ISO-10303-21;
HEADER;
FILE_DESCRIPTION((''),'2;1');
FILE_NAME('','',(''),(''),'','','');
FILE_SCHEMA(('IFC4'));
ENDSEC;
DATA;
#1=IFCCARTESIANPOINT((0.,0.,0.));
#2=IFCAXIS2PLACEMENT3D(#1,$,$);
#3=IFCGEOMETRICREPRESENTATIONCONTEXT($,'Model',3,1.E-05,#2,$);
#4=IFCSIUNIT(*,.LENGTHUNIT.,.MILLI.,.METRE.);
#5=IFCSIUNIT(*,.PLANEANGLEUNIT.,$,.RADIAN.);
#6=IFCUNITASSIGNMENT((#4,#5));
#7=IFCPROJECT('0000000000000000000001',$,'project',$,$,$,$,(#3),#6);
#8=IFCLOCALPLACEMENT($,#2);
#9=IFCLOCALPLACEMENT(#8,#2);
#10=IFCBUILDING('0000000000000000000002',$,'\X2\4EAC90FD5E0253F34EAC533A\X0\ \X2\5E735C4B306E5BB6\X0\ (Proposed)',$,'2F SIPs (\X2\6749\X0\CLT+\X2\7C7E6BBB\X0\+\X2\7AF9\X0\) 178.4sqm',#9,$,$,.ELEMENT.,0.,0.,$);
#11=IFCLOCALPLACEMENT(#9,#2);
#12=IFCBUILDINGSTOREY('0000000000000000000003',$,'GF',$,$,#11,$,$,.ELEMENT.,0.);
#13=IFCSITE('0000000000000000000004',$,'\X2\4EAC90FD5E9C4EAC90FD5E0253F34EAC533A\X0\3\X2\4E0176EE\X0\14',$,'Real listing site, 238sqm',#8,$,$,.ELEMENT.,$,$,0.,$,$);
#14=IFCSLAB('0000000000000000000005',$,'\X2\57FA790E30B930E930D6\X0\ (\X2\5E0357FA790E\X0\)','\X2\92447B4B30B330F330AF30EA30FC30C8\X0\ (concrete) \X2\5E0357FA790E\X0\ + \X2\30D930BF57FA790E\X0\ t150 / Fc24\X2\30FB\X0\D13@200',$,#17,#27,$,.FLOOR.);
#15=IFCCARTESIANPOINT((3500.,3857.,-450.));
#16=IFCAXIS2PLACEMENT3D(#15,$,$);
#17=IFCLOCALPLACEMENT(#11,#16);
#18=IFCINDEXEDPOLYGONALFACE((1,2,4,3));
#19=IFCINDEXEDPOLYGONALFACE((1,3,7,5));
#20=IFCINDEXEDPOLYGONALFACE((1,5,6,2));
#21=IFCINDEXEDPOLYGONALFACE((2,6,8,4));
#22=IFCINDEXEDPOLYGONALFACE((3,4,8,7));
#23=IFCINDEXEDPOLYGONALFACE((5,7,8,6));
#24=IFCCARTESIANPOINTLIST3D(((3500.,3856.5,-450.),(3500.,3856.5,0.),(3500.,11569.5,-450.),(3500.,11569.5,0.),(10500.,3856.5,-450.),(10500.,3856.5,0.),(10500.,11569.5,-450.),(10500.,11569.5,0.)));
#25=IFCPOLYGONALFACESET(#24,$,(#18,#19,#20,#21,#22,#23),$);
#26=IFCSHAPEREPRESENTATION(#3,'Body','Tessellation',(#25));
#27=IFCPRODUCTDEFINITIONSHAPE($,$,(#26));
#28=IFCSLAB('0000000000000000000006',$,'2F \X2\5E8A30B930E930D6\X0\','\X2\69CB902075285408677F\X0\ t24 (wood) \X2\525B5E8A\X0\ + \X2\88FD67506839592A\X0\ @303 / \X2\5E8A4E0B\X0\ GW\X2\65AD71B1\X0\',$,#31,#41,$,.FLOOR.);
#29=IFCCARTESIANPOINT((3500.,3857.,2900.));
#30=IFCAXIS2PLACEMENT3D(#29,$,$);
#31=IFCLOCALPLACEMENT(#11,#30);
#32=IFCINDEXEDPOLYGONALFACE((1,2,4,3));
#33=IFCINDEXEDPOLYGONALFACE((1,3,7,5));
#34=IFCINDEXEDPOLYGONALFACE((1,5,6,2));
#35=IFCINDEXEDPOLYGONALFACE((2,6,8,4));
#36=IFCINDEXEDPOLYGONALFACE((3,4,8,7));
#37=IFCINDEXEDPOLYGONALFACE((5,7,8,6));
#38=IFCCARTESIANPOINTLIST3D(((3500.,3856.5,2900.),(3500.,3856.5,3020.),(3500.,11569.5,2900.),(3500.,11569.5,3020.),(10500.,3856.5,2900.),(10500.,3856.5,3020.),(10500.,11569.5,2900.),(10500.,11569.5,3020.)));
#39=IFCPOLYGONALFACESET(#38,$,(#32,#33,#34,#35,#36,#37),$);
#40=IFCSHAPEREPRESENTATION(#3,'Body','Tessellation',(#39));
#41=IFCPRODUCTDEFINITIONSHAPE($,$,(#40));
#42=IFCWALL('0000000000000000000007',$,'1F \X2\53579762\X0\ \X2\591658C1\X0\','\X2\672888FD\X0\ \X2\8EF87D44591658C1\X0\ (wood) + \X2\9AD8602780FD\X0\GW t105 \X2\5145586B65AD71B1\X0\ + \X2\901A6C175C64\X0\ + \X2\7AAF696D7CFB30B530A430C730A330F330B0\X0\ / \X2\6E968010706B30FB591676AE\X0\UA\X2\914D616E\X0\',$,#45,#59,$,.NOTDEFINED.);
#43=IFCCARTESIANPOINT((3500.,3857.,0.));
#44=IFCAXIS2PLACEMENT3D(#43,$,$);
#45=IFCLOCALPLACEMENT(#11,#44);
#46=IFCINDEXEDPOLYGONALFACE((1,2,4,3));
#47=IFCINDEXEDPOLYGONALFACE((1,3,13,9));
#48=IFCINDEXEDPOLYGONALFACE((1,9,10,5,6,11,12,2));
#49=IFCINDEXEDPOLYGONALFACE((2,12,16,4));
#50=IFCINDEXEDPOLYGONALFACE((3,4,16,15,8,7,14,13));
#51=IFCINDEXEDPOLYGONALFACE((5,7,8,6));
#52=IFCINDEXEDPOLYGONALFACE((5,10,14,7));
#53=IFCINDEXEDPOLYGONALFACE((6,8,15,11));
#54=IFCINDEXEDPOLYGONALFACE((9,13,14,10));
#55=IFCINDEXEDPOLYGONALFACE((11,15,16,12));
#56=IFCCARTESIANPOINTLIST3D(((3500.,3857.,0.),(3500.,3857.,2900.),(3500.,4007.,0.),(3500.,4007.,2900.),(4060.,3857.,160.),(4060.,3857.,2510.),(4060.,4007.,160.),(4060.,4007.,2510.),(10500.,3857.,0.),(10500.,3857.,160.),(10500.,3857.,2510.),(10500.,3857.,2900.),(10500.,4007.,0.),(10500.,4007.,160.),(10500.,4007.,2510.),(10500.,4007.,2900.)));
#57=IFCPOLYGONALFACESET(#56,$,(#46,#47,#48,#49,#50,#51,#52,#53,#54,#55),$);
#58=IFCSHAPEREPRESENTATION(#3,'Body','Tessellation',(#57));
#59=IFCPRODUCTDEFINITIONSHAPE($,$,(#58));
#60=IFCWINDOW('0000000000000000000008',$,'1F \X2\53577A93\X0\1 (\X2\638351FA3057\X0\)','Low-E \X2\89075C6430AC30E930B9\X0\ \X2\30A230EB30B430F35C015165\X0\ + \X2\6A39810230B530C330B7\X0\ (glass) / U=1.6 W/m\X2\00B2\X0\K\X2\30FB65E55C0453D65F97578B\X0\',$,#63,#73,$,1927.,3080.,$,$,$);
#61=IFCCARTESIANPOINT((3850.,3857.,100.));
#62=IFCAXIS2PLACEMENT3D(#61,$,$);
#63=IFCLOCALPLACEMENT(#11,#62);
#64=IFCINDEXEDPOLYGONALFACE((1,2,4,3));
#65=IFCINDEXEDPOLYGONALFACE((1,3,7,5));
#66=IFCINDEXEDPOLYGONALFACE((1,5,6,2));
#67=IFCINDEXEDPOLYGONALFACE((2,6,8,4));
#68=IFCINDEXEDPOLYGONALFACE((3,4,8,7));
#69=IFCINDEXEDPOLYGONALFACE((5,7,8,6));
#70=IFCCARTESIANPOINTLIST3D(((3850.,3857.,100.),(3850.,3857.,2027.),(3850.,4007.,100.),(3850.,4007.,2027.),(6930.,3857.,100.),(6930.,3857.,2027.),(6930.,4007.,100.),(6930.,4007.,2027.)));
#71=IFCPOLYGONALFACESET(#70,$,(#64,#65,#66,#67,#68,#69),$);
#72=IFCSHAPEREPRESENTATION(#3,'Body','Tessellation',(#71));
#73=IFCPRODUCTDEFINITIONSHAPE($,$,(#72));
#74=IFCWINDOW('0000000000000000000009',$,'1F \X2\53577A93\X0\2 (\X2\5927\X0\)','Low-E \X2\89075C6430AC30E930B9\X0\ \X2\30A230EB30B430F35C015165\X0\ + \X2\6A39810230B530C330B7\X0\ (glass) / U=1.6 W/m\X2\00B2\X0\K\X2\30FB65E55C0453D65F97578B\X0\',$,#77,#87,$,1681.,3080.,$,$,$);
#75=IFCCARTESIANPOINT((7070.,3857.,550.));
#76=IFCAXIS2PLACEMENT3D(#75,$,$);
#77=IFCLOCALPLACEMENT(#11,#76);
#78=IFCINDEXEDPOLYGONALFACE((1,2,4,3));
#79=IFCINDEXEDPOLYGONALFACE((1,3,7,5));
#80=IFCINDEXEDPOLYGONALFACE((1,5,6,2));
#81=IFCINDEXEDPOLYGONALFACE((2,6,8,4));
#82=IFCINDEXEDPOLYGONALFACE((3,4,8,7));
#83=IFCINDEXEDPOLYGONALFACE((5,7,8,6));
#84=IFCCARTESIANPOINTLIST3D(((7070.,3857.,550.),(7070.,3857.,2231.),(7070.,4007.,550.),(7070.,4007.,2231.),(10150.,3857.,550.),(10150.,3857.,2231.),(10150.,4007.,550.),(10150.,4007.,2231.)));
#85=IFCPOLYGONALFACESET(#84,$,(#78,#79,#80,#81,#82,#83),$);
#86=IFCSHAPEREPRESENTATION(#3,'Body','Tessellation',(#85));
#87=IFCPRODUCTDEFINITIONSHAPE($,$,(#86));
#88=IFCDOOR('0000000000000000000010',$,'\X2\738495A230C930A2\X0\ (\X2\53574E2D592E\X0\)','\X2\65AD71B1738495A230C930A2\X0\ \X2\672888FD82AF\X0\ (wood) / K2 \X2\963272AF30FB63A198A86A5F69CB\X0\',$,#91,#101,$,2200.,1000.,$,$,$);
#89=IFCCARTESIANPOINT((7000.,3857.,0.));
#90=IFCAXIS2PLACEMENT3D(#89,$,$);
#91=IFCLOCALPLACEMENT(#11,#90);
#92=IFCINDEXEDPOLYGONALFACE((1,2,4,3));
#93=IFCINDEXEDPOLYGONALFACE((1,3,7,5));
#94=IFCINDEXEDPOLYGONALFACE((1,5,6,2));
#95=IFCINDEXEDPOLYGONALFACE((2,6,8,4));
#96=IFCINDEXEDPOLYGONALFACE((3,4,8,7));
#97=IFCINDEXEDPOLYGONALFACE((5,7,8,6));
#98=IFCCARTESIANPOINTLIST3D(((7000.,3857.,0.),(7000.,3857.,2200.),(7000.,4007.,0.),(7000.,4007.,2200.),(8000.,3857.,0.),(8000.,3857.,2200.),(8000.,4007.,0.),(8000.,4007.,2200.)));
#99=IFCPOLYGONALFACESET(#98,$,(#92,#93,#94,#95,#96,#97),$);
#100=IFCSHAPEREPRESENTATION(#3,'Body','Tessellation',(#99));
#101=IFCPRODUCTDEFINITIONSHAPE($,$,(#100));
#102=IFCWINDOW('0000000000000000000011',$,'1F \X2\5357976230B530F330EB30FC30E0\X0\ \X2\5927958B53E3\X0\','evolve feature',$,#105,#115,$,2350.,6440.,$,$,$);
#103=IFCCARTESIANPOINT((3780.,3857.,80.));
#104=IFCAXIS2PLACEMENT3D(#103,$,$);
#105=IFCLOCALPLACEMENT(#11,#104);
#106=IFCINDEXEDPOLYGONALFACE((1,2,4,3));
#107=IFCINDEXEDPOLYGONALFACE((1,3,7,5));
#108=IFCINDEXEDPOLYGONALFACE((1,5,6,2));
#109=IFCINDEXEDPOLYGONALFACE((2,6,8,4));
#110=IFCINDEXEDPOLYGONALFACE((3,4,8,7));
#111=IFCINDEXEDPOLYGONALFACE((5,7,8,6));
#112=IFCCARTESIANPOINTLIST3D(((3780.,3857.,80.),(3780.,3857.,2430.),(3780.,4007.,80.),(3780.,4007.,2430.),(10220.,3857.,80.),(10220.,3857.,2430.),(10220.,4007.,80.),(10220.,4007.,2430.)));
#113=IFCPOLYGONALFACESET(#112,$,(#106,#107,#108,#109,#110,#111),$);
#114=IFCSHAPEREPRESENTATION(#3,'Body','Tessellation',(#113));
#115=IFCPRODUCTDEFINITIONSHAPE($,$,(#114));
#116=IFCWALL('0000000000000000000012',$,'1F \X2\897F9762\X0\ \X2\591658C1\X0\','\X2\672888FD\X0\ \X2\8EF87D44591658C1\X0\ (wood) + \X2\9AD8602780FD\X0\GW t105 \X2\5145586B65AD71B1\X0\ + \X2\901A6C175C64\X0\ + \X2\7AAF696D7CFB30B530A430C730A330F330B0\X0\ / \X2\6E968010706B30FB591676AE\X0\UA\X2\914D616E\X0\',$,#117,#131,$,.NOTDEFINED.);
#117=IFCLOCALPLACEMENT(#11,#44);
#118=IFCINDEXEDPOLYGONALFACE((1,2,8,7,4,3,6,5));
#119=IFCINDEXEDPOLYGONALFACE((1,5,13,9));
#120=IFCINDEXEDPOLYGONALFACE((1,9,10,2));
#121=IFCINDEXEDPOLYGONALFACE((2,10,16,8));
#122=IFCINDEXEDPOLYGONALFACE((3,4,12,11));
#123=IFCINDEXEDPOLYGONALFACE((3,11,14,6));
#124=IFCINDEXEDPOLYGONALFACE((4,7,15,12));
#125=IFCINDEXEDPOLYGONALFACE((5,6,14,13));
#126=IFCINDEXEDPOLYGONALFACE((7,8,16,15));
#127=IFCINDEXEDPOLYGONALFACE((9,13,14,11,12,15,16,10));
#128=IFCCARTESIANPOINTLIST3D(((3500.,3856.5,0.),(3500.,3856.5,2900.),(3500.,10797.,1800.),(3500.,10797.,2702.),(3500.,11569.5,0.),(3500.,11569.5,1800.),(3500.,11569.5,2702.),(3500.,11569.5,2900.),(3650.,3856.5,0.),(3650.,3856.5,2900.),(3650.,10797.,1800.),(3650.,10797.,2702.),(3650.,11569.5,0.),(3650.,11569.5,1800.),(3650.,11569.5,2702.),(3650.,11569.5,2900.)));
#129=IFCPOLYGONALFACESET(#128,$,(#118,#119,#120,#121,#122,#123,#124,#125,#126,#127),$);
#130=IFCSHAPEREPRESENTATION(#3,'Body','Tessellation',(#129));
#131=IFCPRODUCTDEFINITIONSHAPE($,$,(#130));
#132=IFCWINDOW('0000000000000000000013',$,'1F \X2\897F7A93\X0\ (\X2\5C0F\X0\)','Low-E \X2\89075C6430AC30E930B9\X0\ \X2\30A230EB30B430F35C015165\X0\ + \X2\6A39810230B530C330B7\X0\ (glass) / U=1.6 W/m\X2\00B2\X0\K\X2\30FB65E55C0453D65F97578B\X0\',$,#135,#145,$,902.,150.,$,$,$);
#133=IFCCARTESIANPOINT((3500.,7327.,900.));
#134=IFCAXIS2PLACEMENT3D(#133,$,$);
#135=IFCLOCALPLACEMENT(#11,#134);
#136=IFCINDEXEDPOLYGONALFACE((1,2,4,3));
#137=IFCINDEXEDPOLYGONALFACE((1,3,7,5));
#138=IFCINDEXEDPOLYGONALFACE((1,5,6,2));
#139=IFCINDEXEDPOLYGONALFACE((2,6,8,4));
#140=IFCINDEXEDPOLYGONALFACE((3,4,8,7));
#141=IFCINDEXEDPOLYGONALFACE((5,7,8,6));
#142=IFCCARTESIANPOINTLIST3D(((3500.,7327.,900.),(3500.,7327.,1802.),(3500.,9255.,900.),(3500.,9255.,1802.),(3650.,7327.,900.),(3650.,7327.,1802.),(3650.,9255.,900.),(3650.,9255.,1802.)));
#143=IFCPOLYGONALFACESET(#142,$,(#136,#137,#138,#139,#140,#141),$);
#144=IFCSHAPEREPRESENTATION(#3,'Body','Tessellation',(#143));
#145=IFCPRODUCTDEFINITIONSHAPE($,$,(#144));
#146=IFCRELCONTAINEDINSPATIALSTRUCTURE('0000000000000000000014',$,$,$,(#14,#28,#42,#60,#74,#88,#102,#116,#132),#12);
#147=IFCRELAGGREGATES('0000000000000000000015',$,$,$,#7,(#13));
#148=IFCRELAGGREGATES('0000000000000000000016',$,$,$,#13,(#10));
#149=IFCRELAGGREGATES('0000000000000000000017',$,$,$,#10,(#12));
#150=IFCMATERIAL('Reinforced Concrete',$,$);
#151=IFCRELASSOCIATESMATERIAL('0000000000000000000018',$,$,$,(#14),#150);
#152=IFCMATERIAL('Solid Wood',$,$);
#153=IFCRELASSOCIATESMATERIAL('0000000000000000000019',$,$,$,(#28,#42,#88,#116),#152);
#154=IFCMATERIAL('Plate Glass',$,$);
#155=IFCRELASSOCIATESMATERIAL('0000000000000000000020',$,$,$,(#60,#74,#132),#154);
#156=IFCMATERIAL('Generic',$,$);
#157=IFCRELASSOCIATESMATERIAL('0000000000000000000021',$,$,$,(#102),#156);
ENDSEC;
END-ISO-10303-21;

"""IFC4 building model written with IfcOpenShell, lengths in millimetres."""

from ifc_helpers import new_model, si_unit, frame, frame_2d, origin, place, context, project, spatial, rectangle, extrude, material, element, fill, save


model = new_model("IFC4")

# Units and contexts
model_context = context("Model", 3, precision=1e-05, world=origin())
ifc_project = project(units=[si_unit("LENGTHUNIT", "METRE", prefix="MILLI"), si_unit("PLANEANGLEUNIT", "RADIAN")], contexts=[model_context])

# Site, building, storey
site_placement = place(None, origin())
site = spatial("IfcSite", under=ifc_project, at=site_placement, Name="京都府京都市右京区3丁目14", ObjectType="Real listing site, 238sqm", CompositionType="ELEMENT", RefElevation=0.0)
building_placement = place(site_placement, origin())
building = spatial("IfcBuilding", under=site, at=building_placement, Name="京都市右京区 平屋の家 (Proposed)", ObjectType="2F SIPs (杉CLT+籾殻+竹) 178.4sqm", CompositionType="ELEMENT", ElevationOfRefHeight=0.0, ElevationOfTerrain=0.0)
storey_placement = place(building_placement, origin())
storey = spatial("IfcBuildingStorey", under=building, at=storey_placement, Name="GF", CompositionType="ELEMENT", Elevation=0.0)

# Slabs
ifc_material_1 = material(Name="Reinforced Concrete")
slab_1_placement = place(storey_placement, frame((3500.0, 3857.0, -450.0)))
element("IfcSlab", 1, at=slab_1_placement, inside=storey, material=ifc_material_1, Name="基礎スラブ (布基礎)", Description="鉄筋コンクリート (concrete) 布基礎 + ベタ基礎 t150 / Fc24・D13@200", PredefinedType="FLOOR", context=model_context, shape_type="SweptSolid", body=[
    extrude(rectangle(XDim=7000.0, YDim=7713.0, at=frame_2d((3500.0, 3856.0))), frame((3500.0, 3857.0, -450.0)), (0.0, 0.0, 1.0), 450.0),
])
ifc_material_2 = material(Name="Solid Wood")
slab_2_placement = place(storey_placement, frame((3500.0, 3857.0, 2900.0)))
element("IfcSlab", 2, at=slab_2_placement, inside=storey, material=ifc_material_2, Name="2F 床スラブ", Description="構造用合板 t24 (wood) 剛床 + 製材根太 @303 / 床下 GW断熱", PredefinedType="FLOOR", context=model_context, shape_type="SweptSolid", body=[
    extrude(rectangle(XDim=7000.0, YDim=7713.0, at=frame_2d((3500.0, 3856.0))), frame((3500.0, 3857.0, 2900.0)), (0.0, 0.0, 1.0), 120.0),
])
ifc_material_3 = material(Name="Generic")

# Wall, openings, windows, door
wall_1_placement = place(storey_placement, frame((3500.0, 3857.0, 0.0)))
wall_1 = element("IfcWall", 3, at=wall_1_placement, inside=storey, material=ifc_material_2, Name="1F 南面 外壁", Description="木製 軸組外壁 (wood) + 高性能GW t105 充填断熱 + 通気層 + 窯業系サイディング / 準耐火・外皮UA配慮", PredefinedType="NOTDEFINED", context=model_context, shape_type="SweptSolid", body=[
    extrude(rectangle(XDim=7000.0, YDim=150.0, at=frame_2d((3500.0, 75.0))), frame((3500.0, 3857.0, 0.0)), (0.0, 0.0, 1.0), 2900.0),
])
opening_1_placement = place(storey_placement, frame((3850.0, 3857.0, 100.0)))
opening_1 = element("IfcOpeningElement", 4, at=opening_1_placement, cuts=wall_1, PredefinedType="NOTDEFINED", context=model_context, shape_type="SweptSolid", body=[
    extrude(rectangle(XDim=3080.0, YDim=150.0, at=frame_2d((1540.0, 75.0))), frame((3850.0, 3857.0, 100.0)), (0.0, 0.0, 1.0), 1927.0),
])
opening_2_placement = place(storey_placement, frame((7070.0, 3857.0, 550.0)))
opening_2 = element("IfcOpeningElement", 5, at=opening_2_placement, cuts=wall_1, PredefinedType="NOTDEFINED", context=model_context, shape_type="SweptSolid", body=[
    extrude(rectangle(XDim=3080.0, YDim=150.0, at=frame_2d((1540.0, 75.0))), frame((7070.0, 3857.0, 550.0)), (0.0, 0.0, 1.0), 1681.0),
])
opening_3_placement = place(storey_placement, frame((7000.0, 3857.0, 0.0)))
opening_3 = element("IfcOpeningElement", 6, at=opening_3_placement, cuts=wall_1, PredefinedType="NOTDEFINED", context=model_context, shape_type="SweptSolid", body=[
    extrude(rectangle(XDim=1000.0, YDim=150.0, at=frame_2d((500.0, 75.0))), frame((7000.0, 3857.0, 0.0)), (0.0, 0.0, 1.0), 2200.0),
])
opening_4_placement = place(storey_placement, frame((3780.0, 3857.0, 80.0)))
opening_4 = element("IfcOpeningElement", 7, at=opening_4_placement, cuts=wall_1, PredefinedType="NOTDEFINED", context=model_context, shape_type="SweptSolid", body=[
    extrude(rectangle(XDim=6440.0, YDim=150.0, at=frame_2d((3220.0, 75.0))), frame((3780.0, 3857.0, 80.0)), (0.0, 0.0, 1.0), 2350.0),
])
ifc_material_4 = material(Name="Plate Glass")
window_1_placement = place(storey_placement, frame((3850.0, 3857.0, 100.0)))
window_1 = element("IfcWindow", 8, at=window_1_placement, inside=storey, material=ifc_material_4, Name="1F 南窓1 (掃出し)", Description="Low-E 複層ガラス アルゴン封入 + 樹脂サッシ (glass) / U=1.6 W/m²K・日射取得型", OverallHeight=1927.0, OverallWidth=3080.0, context=model_context, shape_type="SweptSolid", body=[
    extrude(rectangle(XDim=3080.0, YDim=150.0, at=frame_2d((1540.0, 75.0))), frame((3850.0, 3857.0, 100.0)), (0.0, 0.0, 1.0), 1927.0),
])
fill(opening_1, window_1)
window_2_placement = place(storey_placement, frame((7070.0, 3857.0, 550.0)))
window_2 = element("IfcWindow", 9, at=window_2_placement, inside=storey, material=ifc_material_4, Name="1F 南窓2 (大)", Description="Low-E 複層ガラス アルゴン封入 + 樹脂サッシ (glass) / U=1.6 W/m²K・日射取得型", OverallHeight=1681.0, OverallWidth=3080.0, context=model_context, shape_type="SweptSolid", body=[
    extrude(rectangle(XDim=3080.0, YDim=150.0, at=frame_2d((1540.0, 75.0))), frame((7070.0, 3857.0, 550.0)), (0.0, 0.0, 1.0), 1681.0),
])
fill(opening_2, window_2)
door_placement = place(storey_placement, frame((7000.0, 3857.0, 0.0)))
door = element("IfcDoor", 10, at=door_placement, inside=storey, material=ifc_material_2, Name="玄関ドア (南中央)", Description="断熱玄関ドア 木製芯 (wood) / K2 防犯・採風機構", OverallHeight=2200.0, OverallWidth=1000.0, context=model_context, shape_type="SweptSolid", body=[
    extrude(rectangle(XDim=1000.0, YDim=150.0, at=frame_2d((500.0, 75.0))), frame((7000.0, 3857.0, 0.0)), (0.0, 0.0, 1.0), 2200.0),
])
fill(opening_3, door)
window_3_placement = place(storey_placement, frame((3780.0, 3857.0, 80.0)))
window_3 = element("IfcWindow", 11, at=window_3_placement, inside=storey, material=ifc_material_3, Name="1F 南面サンルーム 大開口", Description="evolve feature", OverallHeight=2350.0, OverallWidth=6440.0, context=model_context, shape_type="SweptSolid", body=[
    extrude(rectangle(XDim=6440.0, YDim=150.0, at=frame_2d((3220.0, 75.0))), frame((3780.0, 3857.0, 80.0)), (0.0, 0.0, 1.0), 2350.0),
])
fill(opening_4, window_3)

# Wall, opening, window
wall_2_placement = place(storey_placement, frame((3500.0, 3857.0, 0.0)))
wall_2 = element("IfcWall", 12, at=wall_2_placement, inside=storey, material=ifc_material_2, Name="1F 西面 外壁", Description="木製 軸組外壁 (wood) + 高性能GW t105 充填断熱 + 通気層 + 窯業系サイディング / 準耐火・外皮UA配慮", PredefinedType="NOTDEFINED", context=model_context, shape_type="SweptSolid", body=[
    extrude(rectangle(XDim=150.0, YDim=7713.0, at=frame_2d((75.0, 3856.0))), frame((3500.0, 3857.0, 0.0)), (0.0, 0.0, 1.0), 2900.0),
])
opening_5_placement = place(storey_placement, frame((3500.0, 7327.0, 900.0)))
opening_5 = element("IfcOpeningElement", 13, at=opening_5_placement, cuts=wall_2, PredefinedType="NOTDEFINED", context=model_context, shape_type="SweptSolid", body=[
    extrude(rectangle(XDim=150.0, YDim=1928.0, at=frame_2d((75.0, 964.0))), frame((3500.0, 7327.0, 900.0)), (0.0, 0.0, 1.0), 902.0),
])
window_4_placement = place(storey_placement, frame((3500.0, 7327.0, 900.0)))
window_4 = element("IfcWindow", 14, at=window_4_placement, inside=storey, material=ifc_material_4, Name="1F 西窓 (小)", Description="Low-E 複層ガラス アルゴン封入 + 樹脂サッシ (glass) / U=1.6 W/m²K・日射取得型", OverallHeight=902.0, OverallWidth=150.0, context=model_context, shape_type="SweptSolid", body=[
    extrude(rectangle(XDim=150.0, YDim=1928.0, at=frame_2d((75.0, 964.0))), frame((3500.0, 7327.0, 900.0)), (0.0, 0.0, 1.0), 902.0),
])
fill(opening_5, window_4)

save(model, "model.ifc")
